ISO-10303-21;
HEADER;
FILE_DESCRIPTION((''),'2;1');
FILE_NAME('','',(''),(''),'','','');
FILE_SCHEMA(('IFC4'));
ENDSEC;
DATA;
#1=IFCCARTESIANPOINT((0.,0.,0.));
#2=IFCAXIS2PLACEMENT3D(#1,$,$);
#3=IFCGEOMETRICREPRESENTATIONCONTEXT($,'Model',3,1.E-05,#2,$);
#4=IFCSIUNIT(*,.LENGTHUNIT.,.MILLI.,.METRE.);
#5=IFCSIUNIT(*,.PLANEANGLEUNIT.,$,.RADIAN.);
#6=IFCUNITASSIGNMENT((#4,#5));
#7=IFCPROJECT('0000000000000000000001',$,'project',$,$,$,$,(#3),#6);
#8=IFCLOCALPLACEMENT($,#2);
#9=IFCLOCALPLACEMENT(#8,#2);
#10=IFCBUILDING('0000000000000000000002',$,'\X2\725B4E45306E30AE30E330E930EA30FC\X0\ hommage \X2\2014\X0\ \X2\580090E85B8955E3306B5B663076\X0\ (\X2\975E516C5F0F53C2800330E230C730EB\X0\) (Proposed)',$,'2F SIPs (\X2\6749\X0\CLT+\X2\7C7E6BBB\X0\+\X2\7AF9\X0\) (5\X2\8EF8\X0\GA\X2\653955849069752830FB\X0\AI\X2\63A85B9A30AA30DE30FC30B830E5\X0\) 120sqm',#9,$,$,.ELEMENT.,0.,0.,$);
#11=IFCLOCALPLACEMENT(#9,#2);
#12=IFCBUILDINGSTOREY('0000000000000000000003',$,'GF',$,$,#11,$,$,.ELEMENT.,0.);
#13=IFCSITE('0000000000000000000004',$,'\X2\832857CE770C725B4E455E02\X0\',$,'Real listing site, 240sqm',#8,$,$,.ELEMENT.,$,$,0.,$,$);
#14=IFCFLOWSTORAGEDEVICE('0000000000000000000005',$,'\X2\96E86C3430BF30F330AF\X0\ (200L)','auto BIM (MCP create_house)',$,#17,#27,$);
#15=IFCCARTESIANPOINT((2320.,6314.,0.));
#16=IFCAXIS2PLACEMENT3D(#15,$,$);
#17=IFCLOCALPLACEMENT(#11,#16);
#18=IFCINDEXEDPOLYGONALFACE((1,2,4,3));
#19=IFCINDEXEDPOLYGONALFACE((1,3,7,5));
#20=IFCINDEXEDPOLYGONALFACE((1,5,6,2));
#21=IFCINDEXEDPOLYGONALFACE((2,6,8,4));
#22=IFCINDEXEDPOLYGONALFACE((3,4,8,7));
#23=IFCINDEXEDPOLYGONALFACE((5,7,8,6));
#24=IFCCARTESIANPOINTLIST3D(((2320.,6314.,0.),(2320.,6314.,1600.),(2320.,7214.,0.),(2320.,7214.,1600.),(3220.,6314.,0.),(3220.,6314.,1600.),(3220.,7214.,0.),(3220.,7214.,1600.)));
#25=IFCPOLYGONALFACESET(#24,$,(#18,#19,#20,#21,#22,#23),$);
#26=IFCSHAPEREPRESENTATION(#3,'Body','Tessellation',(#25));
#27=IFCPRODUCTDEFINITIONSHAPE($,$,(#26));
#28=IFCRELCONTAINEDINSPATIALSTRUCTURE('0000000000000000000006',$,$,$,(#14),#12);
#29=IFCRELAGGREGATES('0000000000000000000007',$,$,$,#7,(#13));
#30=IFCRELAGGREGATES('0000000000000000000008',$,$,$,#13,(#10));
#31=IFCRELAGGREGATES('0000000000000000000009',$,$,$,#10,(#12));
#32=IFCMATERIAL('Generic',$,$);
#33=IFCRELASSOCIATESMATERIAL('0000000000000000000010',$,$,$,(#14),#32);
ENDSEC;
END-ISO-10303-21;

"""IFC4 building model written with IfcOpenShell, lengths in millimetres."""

from ifc_helpers import new_model, si_unit, frame, frame_2d, origin, place, context, project, spatial, rectangle, extrude, material, element, save


model = new_model("IFC4")

# Units and contexts
model_context = context("Model", 3, precision=1e-05, world=origin())
ifc_project = project(units=[si_unit("LENGTHUNIT", "METRE", prefix="MILLI"), si_unit("PLANEANGLEUNIT", "RADIAN")], contexts=[model_context])

# Site, building, storey
site_placement = place(None, origin())
site = spatial("IfcSite", under=ifc_project, at=site_placement, Name="茨城県牛久市", ObjectType="Real listing site, 240sqm", CompositionType="ELEMENT", RefElevation=0.0)
building_placement = place(site_placement, origin())
building = spatial("IfcBuilding", under=site, at=building_placement, Name="牛久のギャラリー hommage — 堀部安嗣に学ぶ (非公式参考モデル) (Proposed)", ObjectType="2F SIPs (杉CLT+籾殻+竹) (5軸GA改善適用・AI推定オマージュ) 120sqm", CompositionType="ELEMENT", ElevationOfRefHeight=0.0, ElevationOfTerrain=0.0)
storey_placement = place(building_placement, origin())
storey = spatial("IfcBuildingStorey", under=building, at=storey_placement, Name="GF", CompositionType="ELEMENT", Elevation=0.0)

# Shared definitions
ifc_material_1 = material(Name="Generic")

# Flow storage device
flow_storage_device_placement = place(storey_placement, frame((2320.0, 6314.0, 0.0)))
element("IfcFlowStorageDevice", 1, at=flow_storage_device_placement, inside=storey, material=ifc_material_1, Name="雨水タンク (200L)", Description="auto BIM (MCP create_house)", context=model_context, shape_type="SweptSolid", body=[
    extrude(rectangle(XDim=900.0, YDim=900.0, at=frame_2d((450.0, 450.0))), frame((2320.0, 6314.0, 0.0)), (0.0, 0.0, 1.0), 1600.0),
])

save(model, "model.ifc")
